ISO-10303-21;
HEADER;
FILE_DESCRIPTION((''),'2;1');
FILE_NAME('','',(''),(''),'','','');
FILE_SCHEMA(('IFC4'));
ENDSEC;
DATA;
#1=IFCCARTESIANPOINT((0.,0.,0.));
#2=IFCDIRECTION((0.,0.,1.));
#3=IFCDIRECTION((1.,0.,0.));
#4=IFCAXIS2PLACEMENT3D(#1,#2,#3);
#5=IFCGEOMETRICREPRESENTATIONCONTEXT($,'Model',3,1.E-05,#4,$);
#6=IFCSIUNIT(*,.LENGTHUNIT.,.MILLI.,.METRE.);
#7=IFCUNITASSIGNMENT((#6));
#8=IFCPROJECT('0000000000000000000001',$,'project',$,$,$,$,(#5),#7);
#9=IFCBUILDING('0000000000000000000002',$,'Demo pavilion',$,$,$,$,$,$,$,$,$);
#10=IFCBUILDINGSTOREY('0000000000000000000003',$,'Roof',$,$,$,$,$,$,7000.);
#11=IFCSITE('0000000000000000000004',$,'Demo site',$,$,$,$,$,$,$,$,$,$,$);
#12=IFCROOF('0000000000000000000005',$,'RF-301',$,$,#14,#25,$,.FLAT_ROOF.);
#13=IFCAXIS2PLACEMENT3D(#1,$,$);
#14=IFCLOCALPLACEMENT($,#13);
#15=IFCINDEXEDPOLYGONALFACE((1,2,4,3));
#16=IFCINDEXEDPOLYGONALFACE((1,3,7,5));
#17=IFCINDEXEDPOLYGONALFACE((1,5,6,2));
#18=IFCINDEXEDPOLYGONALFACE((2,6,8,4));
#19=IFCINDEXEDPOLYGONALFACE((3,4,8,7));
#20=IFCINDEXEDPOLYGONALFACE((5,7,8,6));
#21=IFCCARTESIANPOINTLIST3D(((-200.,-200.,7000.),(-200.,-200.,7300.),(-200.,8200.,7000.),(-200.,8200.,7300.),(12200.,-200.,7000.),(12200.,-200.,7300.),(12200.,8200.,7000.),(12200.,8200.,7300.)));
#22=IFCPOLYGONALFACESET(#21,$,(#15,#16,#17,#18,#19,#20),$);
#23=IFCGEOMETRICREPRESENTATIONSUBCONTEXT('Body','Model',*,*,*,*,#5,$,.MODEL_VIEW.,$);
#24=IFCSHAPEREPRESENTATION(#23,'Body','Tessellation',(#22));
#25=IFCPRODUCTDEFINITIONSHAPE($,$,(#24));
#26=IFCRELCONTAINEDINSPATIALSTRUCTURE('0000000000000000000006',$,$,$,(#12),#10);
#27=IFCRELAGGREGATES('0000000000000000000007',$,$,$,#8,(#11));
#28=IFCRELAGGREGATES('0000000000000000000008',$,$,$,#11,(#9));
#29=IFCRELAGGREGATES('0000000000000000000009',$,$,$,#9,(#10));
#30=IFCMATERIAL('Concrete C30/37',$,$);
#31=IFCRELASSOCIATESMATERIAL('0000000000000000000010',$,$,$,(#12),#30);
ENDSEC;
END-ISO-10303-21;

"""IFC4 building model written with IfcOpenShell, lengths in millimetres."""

from ifc_helpers import new_model, si_unit, frame, origin_with_axes, place, context, subcontext, project, spatial, indexed_curve, outline, extrude, material, element, save


model = new_model("IFC4")

# Units and contexts
model_context = context("Model", 3, precision=1e-05, world=origin_with_axes())
body_context = subcontext(model_context, "Body", "Model", "MODEL_VIEW")
ifc_project = project(units=[si_unit("LENGTHUNIT", "METRE", prefix="MILLI")], contexts=[model_context])

# Site, building, storey
site = spatial("IfcSite", under=ifc_project, Name="Demo site")
building = spatial("IfcBuilding", under=site, Name="Demo pavilion")
storey = spatial("IfcBuildingStorey", under=building, Name="Roof", Elevation=7000.0)

# Roof
ifc_material = material(Name="Concrete C30/37")
roof_placement = place(None, frame((-200.0, -200.0, 7000.0), z_axis=(0.0, 0.0, 1.0), x_axis=(1.0, 0.0, 0.0)))
element("IfcRoof", 1, at=roof_placement, inside=storey, material=ifc_material, Name="RF-301", PredefinedType="FLAT_ROOF", context=body_context, shape_type="SweptSolid", body=[
    extrude(outline(indexed_curve([(0.0, 0.0), (0.0, 8400.0), (12400.0, 8400.0), (12400.0, 0.0), (0.0, 0.0)], self_intersect=False)), origin_with_axes(), (0.0, 0.0, 1.0), 300.0),
])

save(model, "model.ifc")
